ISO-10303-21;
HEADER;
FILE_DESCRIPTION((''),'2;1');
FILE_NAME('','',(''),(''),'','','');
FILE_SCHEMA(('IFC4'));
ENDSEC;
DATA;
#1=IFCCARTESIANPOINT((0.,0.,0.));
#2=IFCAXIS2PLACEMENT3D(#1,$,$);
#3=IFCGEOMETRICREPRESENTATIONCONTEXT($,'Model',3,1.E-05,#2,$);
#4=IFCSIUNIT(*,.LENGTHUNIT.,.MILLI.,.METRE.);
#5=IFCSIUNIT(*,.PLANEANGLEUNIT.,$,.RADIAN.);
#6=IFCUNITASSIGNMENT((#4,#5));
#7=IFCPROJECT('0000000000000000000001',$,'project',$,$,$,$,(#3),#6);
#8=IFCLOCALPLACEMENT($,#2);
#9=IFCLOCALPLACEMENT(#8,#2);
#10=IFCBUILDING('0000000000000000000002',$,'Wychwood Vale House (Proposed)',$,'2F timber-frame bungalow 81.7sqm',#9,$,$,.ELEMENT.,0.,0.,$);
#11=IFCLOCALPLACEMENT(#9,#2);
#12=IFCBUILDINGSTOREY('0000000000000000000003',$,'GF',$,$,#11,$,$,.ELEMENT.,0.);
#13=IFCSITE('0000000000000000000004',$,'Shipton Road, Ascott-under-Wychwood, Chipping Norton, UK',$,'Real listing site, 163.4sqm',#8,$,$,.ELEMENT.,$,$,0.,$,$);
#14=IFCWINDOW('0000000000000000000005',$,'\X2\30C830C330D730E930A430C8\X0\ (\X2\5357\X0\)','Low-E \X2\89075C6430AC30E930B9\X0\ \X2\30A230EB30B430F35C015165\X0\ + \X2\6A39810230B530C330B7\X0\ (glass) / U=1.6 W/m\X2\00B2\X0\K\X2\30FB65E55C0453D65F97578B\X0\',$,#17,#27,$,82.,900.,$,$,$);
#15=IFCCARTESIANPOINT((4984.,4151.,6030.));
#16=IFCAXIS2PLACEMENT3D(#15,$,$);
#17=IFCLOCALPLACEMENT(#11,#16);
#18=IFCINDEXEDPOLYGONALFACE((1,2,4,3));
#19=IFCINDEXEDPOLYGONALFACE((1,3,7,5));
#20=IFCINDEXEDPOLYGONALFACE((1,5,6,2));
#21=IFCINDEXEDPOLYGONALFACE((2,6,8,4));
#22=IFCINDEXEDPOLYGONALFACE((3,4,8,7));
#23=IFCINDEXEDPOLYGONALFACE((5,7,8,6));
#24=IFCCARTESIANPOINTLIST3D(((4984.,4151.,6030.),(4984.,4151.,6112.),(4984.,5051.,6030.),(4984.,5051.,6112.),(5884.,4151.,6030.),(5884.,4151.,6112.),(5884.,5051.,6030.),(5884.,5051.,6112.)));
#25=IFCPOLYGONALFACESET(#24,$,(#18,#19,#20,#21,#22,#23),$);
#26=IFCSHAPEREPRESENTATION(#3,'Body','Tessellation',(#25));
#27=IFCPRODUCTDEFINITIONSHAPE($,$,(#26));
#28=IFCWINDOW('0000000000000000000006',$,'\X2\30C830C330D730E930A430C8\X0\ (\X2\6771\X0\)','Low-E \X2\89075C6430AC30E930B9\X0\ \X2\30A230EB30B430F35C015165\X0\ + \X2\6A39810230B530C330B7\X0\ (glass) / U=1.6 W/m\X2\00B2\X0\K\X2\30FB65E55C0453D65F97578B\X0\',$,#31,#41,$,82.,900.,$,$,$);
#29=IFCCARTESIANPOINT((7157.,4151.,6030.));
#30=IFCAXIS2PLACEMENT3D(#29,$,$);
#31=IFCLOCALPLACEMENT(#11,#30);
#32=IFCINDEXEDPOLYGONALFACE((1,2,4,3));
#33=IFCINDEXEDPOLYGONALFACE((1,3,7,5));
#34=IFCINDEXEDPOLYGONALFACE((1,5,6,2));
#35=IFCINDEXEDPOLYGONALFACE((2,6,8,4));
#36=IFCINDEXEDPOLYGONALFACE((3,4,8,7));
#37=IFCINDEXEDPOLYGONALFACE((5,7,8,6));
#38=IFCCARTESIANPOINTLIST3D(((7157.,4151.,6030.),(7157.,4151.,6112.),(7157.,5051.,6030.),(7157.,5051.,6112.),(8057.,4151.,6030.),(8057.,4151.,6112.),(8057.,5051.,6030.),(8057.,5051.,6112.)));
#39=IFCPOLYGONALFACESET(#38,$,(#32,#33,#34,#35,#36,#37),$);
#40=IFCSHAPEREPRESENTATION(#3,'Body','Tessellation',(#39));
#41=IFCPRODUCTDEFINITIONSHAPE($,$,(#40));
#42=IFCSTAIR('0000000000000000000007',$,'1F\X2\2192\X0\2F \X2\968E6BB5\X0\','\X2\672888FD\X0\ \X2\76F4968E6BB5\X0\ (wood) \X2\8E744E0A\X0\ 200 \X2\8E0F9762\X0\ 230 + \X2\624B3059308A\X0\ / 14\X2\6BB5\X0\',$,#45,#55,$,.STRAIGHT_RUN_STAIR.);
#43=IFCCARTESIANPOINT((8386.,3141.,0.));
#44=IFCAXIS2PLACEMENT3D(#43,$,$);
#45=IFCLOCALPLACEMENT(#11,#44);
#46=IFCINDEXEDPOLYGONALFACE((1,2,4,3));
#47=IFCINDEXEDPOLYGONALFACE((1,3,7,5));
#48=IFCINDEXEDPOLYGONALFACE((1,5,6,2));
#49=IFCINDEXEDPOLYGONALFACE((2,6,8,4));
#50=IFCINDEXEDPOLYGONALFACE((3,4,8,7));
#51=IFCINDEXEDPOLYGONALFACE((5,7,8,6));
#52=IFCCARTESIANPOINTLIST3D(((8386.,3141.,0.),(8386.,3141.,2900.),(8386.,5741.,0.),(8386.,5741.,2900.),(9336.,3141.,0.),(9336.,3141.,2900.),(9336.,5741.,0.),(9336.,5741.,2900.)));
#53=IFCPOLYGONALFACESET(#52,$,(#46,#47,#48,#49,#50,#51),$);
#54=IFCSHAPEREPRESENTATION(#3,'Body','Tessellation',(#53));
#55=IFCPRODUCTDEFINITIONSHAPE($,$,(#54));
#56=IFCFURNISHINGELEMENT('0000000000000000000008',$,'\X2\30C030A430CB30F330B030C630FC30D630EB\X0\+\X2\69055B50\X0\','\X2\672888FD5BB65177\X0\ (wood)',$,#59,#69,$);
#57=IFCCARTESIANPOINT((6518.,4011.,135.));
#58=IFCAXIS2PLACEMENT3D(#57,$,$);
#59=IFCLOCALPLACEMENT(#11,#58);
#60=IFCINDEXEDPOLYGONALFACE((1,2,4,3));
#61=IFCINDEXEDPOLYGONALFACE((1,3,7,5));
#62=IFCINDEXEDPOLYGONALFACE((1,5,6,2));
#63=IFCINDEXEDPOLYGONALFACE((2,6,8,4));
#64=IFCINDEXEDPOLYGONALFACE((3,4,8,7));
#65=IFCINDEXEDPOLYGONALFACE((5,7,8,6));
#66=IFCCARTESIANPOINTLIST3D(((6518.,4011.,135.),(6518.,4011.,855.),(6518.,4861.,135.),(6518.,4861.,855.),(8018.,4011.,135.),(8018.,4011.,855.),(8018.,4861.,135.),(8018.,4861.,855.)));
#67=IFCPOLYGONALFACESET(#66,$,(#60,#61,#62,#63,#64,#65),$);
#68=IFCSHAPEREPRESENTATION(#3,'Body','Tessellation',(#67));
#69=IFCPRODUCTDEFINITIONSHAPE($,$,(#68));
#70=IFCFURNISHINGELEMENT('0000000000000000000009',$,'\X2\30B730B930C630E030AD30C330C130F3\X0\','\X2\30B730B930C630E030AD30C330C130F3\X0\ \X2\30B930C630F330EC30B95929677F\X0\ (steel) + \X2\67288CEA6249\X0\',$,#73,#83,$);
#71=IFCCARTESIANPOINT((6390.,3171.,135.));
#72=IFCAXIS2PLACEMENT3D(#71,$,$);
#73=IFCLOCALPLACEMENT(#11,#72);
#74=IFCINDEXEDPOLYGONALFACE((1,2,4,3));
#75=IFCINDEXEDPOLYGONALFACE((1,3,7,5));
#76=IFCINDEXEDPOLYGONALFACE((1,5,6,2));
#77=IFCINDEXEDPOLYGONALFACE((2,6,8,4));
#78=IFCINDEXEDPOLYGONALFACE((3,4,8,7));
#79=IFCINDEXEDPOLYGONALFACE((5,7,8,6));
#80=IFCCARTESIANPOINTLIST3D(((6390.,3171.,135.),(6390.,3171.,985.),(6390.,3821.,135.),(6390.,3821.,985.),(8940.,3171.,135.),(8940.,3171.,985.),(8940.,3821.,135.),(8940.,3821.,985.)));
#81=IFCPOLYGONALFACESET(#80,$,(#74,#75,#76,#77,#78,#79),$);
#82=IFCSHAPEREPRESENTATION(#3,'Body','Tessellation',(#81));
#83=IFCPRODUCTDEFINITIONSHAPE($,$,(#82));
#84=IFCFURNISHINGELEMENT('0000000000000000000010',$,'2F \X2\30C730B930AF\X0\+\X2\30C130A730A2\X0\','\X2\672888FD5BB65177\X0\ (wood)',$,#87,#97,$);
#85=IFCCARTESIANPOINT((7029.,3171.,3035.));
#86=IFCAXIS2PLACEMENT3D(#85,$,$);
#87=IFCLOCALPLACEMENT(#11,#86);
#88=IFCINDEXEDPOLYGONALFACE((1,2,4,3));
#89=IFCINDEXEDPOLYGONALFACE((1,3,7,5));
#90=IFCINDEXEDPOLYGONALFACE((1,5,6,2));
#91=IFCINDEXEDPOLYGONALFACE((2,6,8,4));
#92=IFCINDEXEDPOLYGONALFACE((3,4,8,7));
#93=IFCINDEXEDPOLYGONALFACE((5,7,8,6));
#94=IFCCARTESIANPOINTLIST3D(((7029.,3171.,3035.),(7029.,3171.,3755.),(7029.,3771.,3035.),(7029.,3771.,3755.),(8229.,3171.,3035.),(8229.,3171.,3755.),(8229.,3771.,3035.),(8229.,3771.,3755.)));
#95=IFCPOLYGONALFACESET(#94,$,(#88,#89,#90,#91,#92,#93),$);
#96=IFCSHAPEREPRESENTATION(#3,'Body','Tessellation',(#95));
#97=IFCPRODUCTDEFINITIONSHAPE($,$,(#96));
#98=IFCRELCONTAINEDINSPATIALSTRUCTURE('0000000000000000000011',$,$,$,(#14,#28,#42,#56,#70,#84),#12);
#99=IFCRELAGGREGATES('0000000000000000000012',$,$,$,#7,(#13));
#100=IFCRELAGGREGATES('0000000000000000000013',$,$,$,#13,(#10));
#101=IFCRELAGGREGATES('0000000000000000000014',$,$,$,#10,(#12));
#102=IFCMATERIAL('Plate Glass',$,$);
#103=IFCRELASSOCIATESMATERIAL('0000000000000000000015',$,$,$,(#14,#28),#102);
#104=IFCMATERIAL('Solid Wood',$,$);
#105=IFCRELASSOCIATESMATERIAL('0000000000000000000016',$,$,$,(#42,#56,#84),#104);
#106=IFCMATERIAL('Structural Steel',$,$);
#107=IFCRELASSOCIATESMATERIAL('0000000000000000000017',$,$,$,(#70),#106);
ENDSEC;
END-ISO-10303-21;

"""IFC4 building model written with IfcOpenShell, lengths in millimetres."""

from ifc_helpers import new_model, si_unit, frame, frame_2d, origin, place, context, project, spatial, rectangle, extrude, material, element, save


model = new_model("IFC4")

# Units and contexts
model_context = context("Model", 3, precision=1e-05, world=origin())
ifc_project = project(units=[si_unit("LENGTHUNIT", "METRE", prefix="MILLI"), si_unit("PLANEANGLEUNIT", "RADIAN")], contexts=[model_context])

# Site, building, storey
site_placement = place(None, origin())
site = spatial("IfcSite", under=ifc_project, at=site_placement, Name="Shipton Road, Ascott-under-Wychwood, Chipping Norton, UK", ObjectType="Real listing site, 163.4sqm", CompositionType="ELEMENT", RefElevation=0.0)
building_placement = place(site_placement, origin())
building = spatial("IfcBuilding", under=site, at=building_placement, Name="Wychwood Vale House (Proposed)", ObjectType="2F timber-frame bungalow 81.7sqm", CompositionType="ELEMENT", ElevationOfRefHeight=0.0, ElevationOfTerrain=0.0)
storey_placement = place(building_placement, origin())
storey = spatial("IfcBuildingStorey", under=building, at=storey_placement, Name="GF", CompositionType="ELEMENT", Elevation=0.0)

# Shared definitions
ifc_material_1 = material(Name="Solid Wood")

# Shared definitions
ifc_material_2 = material(Name="Plate Glass")

# Windows
window_1_placement = place(storey_placement, frame((4984.0, 4151.0, 6030.0)))
element("IfcWindow", 1, at=window_1_placement, inside=storey, material=ifc_material_2, Name="トップライト (南)", Description="Low-E 複層ガラス アルゴン封入 + 樹脂サッシ (glass) / U=1.6 W/m²K・日射取得型", OverallHeight=82.0, OverallWidth=900.0, context=model_context, shape_type="SweptSolid", body=[
    extrude(rectangle(XDim=900.0, YDim=900.0, at=frame_2d((450.0, 450.0))), frame((4984.0, 4151.0, 6030.0)), (0.0, 0.0, 1.0), 82.0),
])
window_2_placement = place(storey_placement, frame((7157.0, 4151.0, 6030.0)))
element("IfcWindow", 2, at=window_2_placement, inside=storey, material=ifc_material_2, Name="トップライト (東)", Description="Low-E 複層ガラス アルゴン封入 + 樹脂サッシ (glass) / U=1.6 W/m²K・日射取得型", OverallHeight=82.0, OverallWidth=900.0, context=model_context, shape_type="SweptSolid", body=[
    extrude(rectangle(XDim=900.0, YDim=900.0, at=frame_2d((450.0, 450.0))), frame((7157.0, 4151.0, 6030.0)), (0.0, 0.0, 1.0), 82.0),
])

# Stair
stair_placement = place(storey_placement, frame((8386.0, 3141.0, 0.0)))
element("IfcStair", 3, at=stair_placement, inside=storey, material=ifc_material_1, Name="1F→2F 階段", Description="木製 直階段 (wood) 蹴上 200 踏面 230 + 手すり / 14段", PredefinedType="STRAIGHT_RUN_STAIR", context=model_context, shape_type="SweptSolid", body=[
    extrude(rectangle(XDim=950.0, YDim=2600.0, at=frame_2d((475.0, 1300.0))), frame((8386.0, 3141.0, 0.0)), (0.0, 0.0, 1.0), 2900.0),
])

# Furnishing elements
furnishing_1_placement = place(storey_placement, frame((6518.0, 4011.0, 135.0)))
element("IfcFurnishingElement", 4, at=furnishing_1_placement, inside=storey, material=ifc_material_1, Name="ダイニングテーブル+椅子", Description="木製家具 (wood)", context=model_context, shape_type="SweptSolid", body=[
    extrude(rectangle(XDim=1500.0, YDim=850.0, at=frame_2d((750.0, 425.0))), frame((6518.0, 4011.0, 135.0)), (0.0, 0.0, 1.0), 720.0),
])
ifc_material_3 = material(Name="Structural Steel")
furnishing_2_placement = place(storey_placement, frame((6390.0, 3171.0, 135.0)))
element("IfcFurnishingElement", 5, at=furnishing_2_placement, inside=storey, material=ifc_material_3, Name="システムキッチン", Description="システムキッチン ステンレス天板 (steel) + 木質扉", context=model_context, shape_type="SweptSolid", body=[
    extrude(rectangle(XDim=2550.0, YDim=650.0, at=frame_2d((1275.0, 325.0))), frame((6390.0, 3171.0, 135.0)), (0.0, 0.0, 1.0), 850.0),
])
furnishing_3_placement = place(storey_placement, frame((7029.0, 3171.0, 3035.0)))
element("IfcFurnishingElement", 6, at=furnishing_3_placement, inside=storey, material=ifc_material_1, Name="2F デスク+チェア", Description="木製家具 (wood)", context=model_context, shape_type="SweptSolid", body=[
    extrude(rectangle(XDim=1200.0, YDim=600.0, at=frame_2d((600.0, 300.0))), frame((7029.0, 3171.0, 3035.0)), (0.0, 0.0, 1.0), 720.0),
])

save(model, "model.ifc")
